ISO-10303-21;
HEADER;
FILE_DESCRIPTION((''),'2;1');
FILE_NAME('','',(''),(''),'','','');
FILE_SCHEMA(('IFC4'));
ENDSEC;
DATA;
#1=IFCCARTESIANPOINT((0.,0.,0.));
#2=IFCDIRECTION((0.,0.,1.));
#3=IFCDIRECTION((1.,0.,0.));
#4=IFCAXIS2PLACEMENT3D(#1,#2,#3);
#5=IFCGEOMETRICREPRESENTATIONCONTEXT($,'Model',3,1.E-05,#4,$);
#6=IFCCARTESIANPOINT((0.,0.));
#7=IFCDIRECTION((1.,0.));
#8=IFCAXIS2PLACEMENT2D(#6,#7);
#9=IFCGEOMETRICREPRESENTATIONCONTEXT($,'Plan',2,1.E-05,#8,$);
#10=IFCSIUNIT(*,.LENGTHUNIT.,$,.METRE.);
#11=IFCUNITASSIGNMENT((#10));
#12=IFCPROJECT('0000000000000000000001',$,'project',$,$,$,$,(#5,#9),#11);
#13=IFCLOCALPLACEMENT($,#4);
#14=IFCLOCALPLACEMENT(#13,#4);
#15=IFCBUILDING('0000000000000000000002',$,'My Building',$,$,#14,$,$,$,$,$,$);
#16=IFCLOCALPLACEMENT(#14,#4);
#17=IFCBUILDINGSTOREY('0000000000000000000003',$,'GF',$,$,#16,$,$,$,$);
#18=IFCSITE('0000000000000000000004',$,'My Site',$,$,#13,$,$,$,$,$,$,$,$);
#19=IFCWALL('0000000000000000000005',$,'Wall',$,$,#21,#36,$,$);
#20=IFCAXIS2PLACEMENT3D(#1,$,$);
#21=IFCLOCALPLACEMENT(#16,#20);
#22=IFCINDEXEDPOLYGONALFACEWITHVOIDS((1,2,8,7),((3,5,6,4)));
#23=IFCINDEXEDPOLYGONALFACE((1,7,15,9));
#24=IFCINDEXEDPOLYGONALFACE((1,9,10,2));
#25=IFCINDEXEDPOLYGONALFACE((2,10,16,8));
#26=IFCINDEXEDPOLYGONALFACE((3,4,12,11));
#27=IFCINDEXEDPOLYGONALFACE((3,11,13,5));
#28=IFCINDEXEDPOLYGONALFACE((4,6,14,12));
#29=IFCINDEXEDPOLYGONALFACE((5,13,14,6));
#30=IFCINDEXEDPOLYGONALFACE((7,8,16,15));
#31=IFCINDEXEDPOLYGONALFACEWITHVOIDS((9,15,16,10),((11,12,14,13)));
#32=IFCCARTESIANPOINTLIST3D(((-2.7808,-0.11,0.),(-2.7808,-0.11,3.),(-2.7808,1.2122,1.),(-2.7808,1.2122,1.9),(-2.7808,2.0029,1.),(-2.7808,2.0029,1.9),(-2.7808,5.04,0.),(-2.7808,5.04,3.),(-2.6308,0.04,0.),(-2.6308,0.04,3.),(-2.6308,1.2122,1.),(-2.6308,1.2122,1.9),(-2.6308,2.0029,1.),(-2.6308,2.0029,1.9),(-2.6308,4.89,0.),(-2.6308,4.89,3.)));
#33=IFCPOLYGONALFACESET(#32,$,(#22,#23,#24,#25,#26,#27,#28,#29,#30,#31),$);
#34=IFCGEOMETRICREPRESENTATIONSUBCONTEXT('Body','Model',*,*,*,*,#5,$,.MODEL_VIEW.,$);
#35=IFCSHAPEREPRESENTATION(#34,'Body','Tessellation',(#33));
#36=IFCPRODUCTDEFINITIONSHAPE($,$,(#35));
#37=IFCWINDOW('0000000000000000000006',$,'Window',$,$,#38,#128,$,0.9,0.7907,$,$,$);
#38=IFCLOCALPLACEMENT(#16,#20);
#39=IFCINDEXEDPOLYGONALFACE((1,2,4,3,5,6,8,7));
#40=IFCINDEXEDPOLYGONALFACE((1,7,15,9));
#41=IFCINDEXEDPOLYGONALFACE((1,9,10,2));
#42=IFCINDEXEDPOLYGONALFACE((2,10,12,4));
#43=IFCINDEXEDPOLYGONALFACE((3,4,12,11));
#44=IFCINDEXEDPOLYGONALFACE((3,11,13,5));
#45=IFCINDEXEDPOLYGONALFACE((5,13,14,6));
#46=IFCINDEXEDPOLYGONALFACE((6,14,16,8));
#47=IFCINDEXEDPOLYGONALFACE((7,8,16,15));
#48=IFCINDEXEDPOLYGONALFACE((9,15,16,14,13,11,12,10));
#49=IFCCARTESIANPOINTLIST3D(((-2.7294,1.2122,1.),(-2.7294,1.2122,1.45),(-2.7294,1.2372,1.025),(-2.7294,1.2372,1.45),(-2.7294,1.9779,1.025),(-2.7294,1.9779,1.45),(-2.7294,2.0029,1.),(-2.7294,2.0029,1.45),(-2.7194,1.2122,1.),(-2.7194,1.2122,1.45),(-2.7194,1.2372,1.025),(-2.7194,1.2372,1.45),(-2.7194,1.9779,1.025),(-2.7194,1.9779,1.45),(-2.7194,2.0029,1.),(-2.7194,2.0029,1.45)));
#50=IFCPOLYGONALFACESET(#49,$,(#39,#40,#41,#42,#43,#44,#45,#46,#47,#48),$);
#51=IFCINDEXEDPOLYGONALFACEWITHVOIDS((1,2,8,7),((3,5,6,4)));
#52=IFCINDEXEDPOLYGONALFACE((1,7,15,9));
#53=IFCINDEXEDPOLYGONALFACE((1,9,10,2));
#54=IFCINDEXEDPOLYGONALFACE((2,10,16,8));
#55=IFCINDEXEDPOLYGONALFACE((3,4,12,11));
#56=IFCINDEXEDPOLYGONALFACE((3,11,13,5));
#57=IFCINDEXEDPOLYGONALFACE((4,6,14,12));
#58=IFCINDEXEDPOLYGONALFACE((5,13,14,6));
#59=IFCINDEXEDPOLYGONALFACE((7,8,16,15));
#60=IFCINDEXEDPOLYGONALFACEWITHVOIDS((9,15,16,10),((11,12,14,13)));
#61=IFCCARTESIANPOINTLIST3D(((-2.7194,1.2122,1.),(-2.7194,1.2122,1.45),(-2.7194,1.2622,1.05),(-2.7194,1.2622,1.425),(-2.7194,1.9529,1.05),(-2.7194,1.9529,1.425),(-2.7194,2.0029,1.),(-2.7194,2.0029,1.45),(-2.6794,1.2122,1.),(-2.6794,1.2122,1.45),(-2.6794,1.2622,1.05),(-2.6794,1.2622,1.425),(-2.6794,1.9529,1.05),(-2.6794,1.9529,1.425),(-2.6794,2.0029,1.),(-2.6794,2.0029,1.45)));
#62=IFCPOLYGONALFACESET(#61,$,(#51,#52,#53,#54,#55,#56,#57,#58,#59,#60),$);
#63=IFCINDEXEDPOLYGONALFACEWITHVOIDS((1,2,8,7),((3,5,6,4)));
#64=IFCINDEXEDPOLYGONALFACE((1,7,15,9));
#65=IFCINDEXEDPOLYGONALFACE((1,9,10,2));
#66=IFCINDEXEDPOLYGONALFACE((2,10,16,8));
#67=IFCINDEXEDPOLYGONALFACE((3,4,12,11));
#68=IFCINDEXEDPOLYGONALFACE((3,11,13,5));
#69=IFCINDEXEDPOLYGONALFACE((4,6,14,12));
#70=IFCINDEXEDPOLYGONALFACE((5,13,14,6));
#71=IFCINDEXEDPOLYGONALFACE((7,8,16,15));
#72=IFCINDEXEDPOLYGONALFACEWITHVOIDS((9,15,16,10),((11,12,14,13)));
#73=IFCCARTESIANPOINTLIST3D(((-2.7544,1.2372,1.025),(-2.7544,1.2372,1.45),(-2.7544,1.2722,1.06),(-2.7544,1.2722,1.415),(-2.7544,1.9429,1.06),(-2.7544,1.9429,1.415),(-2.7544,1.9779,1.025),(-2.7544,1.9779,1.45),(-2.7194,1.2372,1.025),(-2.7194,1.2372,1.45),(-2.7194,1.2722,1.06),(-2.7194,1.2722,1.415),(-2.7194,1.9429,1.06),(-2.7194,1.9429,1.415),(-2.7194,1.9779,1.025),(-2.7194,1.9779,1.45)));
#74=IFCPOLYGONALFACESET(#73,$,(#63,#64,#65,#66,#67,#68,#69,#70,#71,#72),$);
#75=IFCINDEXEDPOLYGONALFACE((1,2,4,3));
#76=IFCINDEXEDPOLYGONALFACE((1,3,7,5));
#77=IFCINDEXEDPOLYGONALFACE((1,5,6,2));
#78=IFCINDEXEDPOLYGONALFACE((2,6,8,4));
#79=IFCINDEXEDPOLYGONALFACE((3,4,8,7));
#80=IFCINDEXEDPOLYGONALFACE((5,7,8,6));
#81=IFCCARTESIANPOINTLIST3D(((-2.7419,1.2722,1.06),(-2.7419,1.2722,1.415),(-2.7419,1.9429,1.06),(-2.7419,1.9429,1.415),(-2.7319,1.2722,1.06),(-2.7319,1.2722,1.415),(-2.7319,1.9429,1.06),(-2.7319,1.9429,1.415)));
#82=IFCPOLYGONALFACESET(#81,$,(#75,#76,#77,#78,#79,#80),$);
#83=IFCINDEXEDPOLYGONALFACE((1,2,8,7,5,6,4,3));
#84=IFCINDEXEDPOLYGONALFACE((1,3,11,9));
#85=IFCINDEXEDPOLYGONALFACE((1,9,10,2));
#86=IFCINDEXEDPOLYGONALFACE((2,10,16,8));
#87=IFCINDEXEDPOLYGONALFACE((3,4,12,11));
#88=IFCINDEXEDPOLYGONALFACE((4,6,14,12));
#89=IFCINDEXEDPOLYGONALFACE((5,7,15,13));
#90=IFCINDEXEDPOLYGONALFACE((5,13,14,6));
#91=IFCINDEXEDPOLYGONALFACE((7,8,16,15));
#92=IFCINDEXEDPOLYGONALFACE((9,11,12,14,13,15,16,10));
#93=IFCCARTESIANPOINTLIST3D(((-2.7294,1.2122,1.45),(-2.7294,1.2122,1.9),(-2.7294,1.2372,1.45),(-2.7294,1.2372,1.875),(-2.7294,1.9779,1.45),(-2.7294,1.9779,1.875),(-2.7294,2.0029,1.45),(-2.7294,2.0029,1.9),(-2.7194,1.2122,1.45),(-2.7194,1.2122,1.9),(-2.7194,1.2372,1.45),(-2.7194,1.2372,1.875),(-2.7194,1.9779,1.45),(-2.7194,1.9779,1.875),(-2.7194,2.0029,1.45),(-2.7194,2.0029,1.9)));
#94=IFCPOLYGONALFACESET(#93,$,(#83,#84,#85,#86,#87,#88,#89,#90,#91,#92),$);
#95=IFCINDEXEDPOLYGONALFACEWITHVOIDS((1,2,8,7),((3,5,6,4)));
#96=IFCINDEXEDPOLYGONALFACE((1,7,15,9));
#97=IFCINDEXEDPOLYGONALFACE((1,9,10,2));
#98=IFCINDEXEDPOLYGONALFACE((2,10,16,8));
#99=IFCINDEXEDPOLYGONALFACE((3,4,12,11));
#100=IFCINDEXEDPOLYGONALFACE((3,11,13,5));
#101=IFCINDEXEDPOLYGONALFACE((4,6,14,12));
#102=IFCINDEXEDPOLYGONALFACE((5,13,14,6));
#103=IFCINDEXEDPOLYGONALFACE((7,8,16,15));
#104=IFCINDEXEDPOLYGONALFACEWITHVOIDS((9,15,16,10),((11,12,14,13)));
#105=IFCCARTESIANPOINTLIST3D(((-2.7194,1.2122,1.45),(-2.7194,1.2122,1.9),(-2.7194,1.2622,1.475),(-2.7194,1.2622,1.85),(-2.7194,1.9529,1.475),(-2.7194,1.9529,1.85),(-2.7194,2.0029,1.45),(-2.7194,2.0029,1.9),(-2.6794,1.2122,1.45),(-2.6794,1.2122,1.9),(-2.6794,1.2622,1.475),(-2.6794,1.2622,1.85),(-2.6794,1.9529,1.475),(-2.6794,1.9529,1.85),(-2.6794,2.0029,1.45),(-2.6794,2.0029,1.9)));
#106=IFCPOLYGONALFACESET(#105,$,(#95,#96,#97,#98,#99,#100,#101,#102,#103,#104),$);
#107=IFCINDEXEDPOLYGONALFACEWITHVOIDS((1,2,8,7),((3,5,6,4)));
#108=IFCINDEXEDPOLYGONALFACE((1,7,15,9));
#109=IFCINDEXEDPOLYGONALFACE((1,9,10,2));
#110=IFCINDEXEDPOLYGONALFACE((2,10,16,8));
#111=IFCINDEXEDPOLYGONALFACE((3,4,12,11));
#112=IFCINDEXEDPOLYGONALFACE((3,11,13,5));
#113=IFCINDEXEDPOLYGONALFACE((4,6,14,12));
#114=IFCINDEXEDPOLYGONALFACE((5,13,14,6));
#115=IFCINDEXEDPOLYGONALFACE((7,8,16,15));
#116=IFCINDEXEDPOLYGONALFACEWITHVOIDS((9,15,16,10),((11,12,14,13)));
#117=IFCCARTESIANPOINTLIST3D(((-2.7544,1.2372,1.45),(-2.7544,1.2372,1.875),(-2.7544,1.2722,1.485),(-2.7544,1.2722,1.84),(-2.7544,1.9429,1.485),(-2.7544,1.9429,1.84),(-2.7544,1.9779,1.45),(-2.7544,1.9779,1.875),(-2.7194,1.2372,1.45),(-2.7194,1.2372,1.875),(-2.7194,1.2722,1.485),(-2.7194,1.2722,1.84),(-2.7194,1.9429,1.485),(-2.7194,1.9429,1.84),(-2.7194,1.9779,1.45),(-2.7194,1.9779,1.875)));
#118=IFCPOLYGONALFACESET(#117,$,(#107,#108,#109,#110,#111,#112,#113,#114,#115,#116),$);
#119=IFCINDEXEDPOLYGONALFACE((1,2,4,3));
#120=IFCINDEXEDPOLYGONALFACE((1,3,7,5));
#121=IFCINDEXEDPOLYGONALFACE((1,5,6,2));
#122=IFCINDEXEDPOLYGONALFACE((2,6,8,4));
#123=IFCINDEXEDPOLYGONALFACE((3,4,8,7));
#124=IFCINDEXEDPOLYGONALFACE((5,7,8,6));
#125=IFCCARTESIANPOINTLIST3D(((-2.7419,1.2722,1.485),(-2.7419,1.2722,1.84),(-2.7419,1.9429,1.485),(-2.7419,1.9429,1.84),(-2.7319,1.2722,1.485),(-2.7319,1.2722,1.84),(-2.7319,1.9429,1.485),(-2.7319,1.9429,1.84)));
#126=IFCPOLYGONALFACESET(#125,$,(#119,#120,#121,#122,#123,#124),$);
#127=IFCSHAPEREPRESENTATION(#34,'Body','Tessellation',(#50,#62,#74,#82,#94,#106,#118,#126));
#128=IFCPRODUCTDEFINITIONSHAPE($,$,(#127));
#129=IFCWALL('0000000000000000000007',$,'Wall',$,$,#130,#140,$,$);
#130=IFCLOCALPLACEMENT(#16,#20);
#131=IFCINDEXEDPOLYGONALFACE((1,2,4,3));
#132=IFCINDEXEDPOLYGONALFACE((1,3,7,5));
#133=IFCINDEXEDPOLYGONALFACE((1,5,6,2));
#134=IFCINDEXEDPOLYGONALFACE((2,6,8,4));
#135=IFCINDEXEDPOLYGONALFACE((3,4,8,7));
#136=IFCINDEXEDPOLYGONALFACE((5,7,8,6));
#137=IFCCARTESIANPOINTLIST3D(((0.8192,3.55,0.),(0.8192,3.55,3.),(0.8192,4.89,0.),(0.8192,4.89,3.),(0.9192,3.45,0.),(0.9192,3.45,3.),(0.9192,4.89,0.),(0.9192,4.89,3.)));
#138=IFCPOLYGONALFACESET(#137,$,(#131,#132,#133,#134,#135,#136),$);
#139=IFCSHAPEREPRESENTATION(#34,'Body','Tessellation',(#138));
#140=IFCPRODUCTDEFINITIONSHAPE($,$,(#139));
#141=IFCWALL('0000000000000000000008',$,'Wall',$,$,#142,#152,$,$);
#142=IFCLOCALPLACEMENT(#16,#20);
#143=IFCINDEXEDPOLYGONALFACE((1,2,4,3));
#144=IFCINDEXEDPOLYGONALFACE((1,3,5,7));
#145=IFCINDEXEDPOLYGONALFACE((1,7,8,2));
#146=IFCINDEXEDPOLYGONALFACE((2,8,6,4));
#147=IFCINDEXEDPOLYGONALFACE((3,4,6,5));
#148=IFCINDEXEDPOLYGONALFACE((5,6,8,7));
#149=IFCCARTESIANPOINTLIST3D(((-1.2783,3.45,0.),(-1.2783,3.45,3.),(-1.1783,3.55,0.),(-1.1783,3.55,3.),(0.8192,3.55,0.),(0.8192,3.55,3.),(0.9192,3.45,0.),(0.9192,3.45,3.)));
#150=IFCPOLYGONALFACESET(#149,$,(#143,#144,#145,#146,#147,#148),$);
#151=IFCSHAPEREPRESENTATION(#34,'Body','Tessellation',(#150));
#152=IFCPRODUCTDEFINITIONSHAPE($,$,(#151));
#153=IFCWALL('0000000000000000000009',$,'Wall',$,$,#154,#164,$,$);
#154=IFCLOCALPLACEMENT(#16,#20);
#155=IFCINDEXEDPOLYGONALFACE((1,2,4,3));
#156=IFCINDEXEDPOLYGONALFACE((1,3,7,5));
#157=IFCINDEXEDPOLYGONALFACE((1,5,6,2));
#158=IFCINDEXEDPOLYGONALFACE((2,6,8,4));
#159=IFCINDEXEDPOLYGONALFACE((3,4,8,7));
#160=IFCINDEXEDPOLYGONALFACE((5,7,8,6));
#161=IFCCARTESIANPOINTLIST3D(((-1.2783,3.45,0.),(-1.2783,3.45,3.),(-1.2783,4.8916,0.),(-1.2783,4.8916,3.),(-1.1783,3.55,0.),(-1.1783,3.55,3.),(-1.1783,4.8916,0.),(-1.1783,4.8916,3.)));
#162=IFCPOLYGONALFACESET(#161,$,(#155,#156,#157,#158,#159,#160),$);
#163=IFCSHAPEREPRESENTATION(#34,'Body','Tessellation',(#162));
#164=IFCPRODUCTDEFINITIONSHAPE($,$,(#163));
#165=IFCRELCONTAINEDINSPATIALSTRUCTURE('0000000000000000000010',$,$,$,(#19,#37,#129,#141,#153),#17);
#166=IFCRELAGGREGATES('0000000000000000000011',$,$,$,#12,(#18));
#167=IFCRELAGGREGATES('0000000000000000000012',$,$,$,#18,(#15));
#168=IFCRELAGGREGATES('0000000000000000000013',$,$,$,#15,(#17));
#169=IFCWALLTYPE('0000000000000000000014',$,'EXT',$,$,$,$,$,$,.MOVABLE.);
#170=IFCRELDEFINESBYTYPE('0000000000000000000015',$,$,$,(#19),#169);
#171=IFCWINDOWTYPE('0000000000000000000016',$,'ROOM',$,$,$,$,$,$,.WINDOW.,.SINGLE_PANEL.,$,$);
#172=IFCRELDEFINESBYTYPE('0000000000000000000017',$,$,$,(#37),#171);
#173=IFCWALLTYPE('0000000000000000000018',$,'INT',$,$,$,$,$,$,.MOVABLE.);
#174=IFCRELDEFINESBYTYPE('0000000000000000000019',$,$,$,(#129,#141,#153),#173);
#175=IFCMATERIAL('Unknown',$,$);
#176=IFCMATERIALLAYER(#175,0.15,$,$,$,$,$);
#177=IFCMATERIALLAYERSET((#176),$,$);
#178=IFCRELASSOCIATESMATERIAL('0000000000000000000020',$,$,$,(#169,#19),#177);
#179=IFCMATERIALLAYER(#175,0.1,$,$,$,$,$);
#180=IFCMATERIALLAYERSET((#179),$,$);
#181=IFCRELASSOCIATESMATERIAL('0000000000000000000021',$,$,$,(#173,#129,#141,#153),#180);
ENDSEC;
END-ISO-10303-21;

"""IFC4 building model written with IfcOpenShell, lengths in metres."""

from ifc_helpers import new_model, entity, si_unit, frame, origin_with_axes, origin_2d_with_axis, place, context, subcontext, project, spatial, line, indexed_curve, outline, extrude, shape, source, transform, mapped, material, layer, layer_set, layer_usage, type_object, type_shapes, element, fill, save


model = new_model("IFC4")

# Units and contexts
model_context = context("Model", 3, precision=1e-05, world=origin_with_axes())
plan_context = context("Plan", 2, precision=1e-05, world=origin_2d_with_axis())
body_context_1 = subcontext(model_context, "Body", "Model", "MODEL_VIEW")
body_context_2 = subcontext(plan_context, "Body", "Plan", "PLAN_VIEW")
ifc_project = project(units=[si_unit("LENGTHUNIT", "METRE")], contexts=[model_context, plan_context])

# Site, building, storey
site_placement = place(None, origin_with_axes())
site = spatial("IfcSite", under=ifc_project, at=site_placement, Name="My Site")
building_placement = place(site_placement, origin_with_axes())
building = spatial("IfcBuilding", under=site, at=building_placement, Name="My Building")
storey_placement = place(building_placement, origin_with_axes())
storey = spatial("IfcBuildingStorey", under=building, at=storey_placement, Name="GF")

# Shared definitions
ifc_material = material(Name="Unknown")

# Shared definitions
ifc_layer_1 = layer(ifc_material, 0.15)
ifc_layer_set_1 = layer_set([ifc_layer_1])
wall_type_1 = type_object("IfcWallType", Name="EXT", PredefinedType="MOVABLE", material=ifc_layer_set_1)

# Shared definitions
window_type_1 = type_object("IfcWindowType", Name="ROOM", PartitioningType="SINGLE_PANEL", PredefinedType="WINDOW")
shared_shape_1 = source(origin_with_axes(), body_context_1, "Body", "SweptSolid", [
    extrude(outline(indexed_curve([(0.7907, 0.45), (0.7907, 0.0), (0.0, 0.0), (0.0, 0.45), (0.025, 0.45), (0.025, 0.025), (0.7657, 0.025), (0.7657, 0.45)], segments=[line(1, 2, 3, 4, 5, 6, 7, 8, 1)])), frame((0.0, 0.09, 0.0), z_axis=(0.0, -1.0, 0.0), x_axis=(1.0, 0.0, 0.0)), (0.0, 0.0, -1.0), 0.01),
    extrude(outline(indexed_curve([(0.0, 0.0), (0.7907, 0.0), (0.7907, 0.45), (0.0, 0.45)], segments=[line(1, 2, 3, 4, 1)]), holes=[indexed_curve([(0.05, 0.05), (0.7407, 0.05), (0.7407, 0.425), (0.05, 0.425)], segments=[line(1, 2, 3, 4, 1)])]), frame((0.0, 0.05, 0.0), z_axis=(0.0, -1.0, 0.0), x_axis=(1.0, 0.0, 0.0)), (0.0, 0.0, -1.0), 0.04),
    extrude(outline(indexed_curve([(0.0, 0.0), (0.7407, 0.0), (0.7407, 0.425), (0.0, 0.425)], segments=[line(1, 2, 3, 4, 1)]), holes=[indexed_curve([(0.035, 0.035), (0.7057, 0.035), (0.7057, 0.39), (0.035, 0.39)], segments=[line(1, 2, 3, 4, 1)])]), frame((0.025, 0.09, 0.025), z_axis=(0.0, -1.0, 0.0), x_axis=(1.0, 0.0, 0.0)), (0.0, 0.0, -1.0), 0.035),
    extrude(outline(indexed_curve([(0.035, 0.035), (0.7057, 0.035), (0.7057, 0.39), (0.035, 0.39)], segments=[line(1, 2, 3, 4, 1)])), frame((0.025, 0.1025, 0.025), z_axis=(0.0, -1.0, 0.0), x_axis=(1.0, 0.0, 0.0)), (0.0, 0.0, -1.0), 0.01),
    extrude(outline(indexed_curve([(0.0, 0.0), (0.0, 0.45), (0.7907, 0.45), (0.7907, 0.0), (0.7657, 0.0), (0.7657, 0.425), (0.025, 0.425), (0.025, 0.0)], segments=[line(1, 2, 3, 4, 5, 6, 7, 8, 1)])), frame((0.0, 0.09, 0.45), z_axis=(0.0, -1.0, 0.0), x_axis=(1.0, 0.0, 0.0)), (0.0, 0.0, -1.0), 0.01),
    extrude(outline(indexed_curve([(0.0, 0.0), (0.7907, 0.0), (0.7907, 0.45), (0.0, 0.45)], segments=[line(1, 2, 3, 4, 1)]), holes=[indexed_curve([(0.05, 0.025), (0.7407, 0.025), (0.7407, 0.4), (0.05, 0.4)], segments=[line(1, 2, 3, 4, 1)])]), frame((0.0, 0.05, 0.45), z_axis=(0.0, -1.0, 0.0), x_axis=(1.0, 0.0, 0.0)), (0.0, 0.0, -1.0), 0.04),
    extrude(outline(indexed_curve([(0.0, 0.0), (0.7407, 0.0), (0.7407, 0.425), (0.0, 0.425)], segments=[line(1, 2, 3, 4, 1)]), holes=[indexed_curve([(0.035, 0.035), (0.7057, 0.035), (0.7057, 0.39), (0.035, 0.39)], segments=[line(1, 2, 3, 4, 1)])]), frame((0.025, 0.09, 0.45), z_axis=(0.0, -1.0, 0.0), x_axis=(1.0, 0.0, 0.0)), (0.0, 0.0, -1.0), 0.035),
    extrude(outline(indexed_curve([(0.035, 0.035), (0.7057, 0.035), (0.7057, 0.39), (0.035, 0.39)], segments=[line(1, 2, 3, 4, 1)])), frame((0.025, 0.1025, 0.45), z_axis=(0.0, -1.0, 0.0), x_axis=(1.0, 0.0, 0.0)), (0.0, 0.0, -1.0), 0.01),
])
shared_shape_2 = source(origin_with_axes(), body_context_2, "Body", "Curve2D", [
    entity("IfcIndexedPolyCurve", entity("IfcCartesianPointList2D", [[0.05, 0.05], [0.7407, 0.05]])),
    entity("IfcIndexedPolyCurve", entity("IfcCartesianPointList2D", [[0.0, 0.1], [0.025, 0.1], [0.025, 0.09], [0.05, 0.09], [0.05, 0.05], [0.0, 0.05]]), [entity("IfcLineIndex", [1, 2, 3, 4, 5, 6, 1])]),
    entity("IfcIndexedPolyCurve", entity("IfcCartesianPointList2D", [[0.7907, 0.1], [0.7657, 0.1], [0.7657, 0.09], [0.7407, 0.09], [0.7407, 0.05], [0.7907, 0.05]]), [entity("IfcLineIndex", [1, 2, 3, 4, 5, 6, 1])]),
    entity("IfcIndexedPolyCurve", entity("IfcCartesianPointList2D", [[0.025, 0.09], [0.06, 0.09], [0.06, 0.125], [0.025, 0.125]]), [entity("IfcLineIndex", [1, 2, 3, 4, 1])]),
    entity("IfcIndexedPolyCurve", entity("IfcCartesianPointList2D", [[0.7657, 0.09], [0.7307, 0.09], [0.7307, 0.125], [0.7657, 0.125]]), [entity("IfcLineIndex", [1, 2, 3, 4, 1])]),
    entity("IfcIndexedPolyCurve", entity("IfcCartesianPointList2D", [[0.06, 0.09], [0.7307, 0.09]])),
    entity("IfcIndexedPolyCurve", entity("IfcCartesianPointList2D", [[0.06, 0.125], [0.7307, 0.125]])),
    entity("IfcIndexedPolyCurve", entity("IfcCartesianPointList2D", [[0.06, 0.1075], [0.7307, 0.1075]])),
])
type_shapes(window_type_1, [shared_shape_1, shared_shape_2])

# Wall, opening, window
ifc_layer_usage_1 = layer_usage(ifc_layer_set_1, "AXIS2", "POSITIVE", 0.0)
wall_1_placement = place(storey_placement, frame((-2.7808, 5.04, 0.0), z_axis=(0.0, 0.0, 1.0), x_axis=(0.0, -1.0, 0.0)))
wall_1 = element("IfcWall", 1, at=wall_1_placement, inside=storey, type_object=wall_type_1, material=ifc_layer_usage_1, Name="Wall", context=body_context_1, shape_type="SweptSolid", body=[
    extrude(outline(indexed_curve([(0.0, 0.0), (0.15, 0.15), (5.0, 0.15), (5.15, 0.0)], segments=[line(1, 2, 3, 4, 1)])), origin_with_axes(), (0.0, 0.0, 1.0), 3.0),
])
placement_1 = place(storey_placement, frame((-2.6294, 1.2122, 1.0), z_axis=(0.0, 0.0, 1.0), x_axis=(0.0, 1.0, 0.0)))
opening_1 = element("IfcOpeningElement", 2, at=placement_1, cuts=wall_1, PredefinedType="OPENING", context=body_context_1, shape_type="SweptSolid", body=[
    extrude(outline(indexed_curve([(0.0, 0.0), (0.7907, 0.0), (0.7907, 0.9), (0.0, 0.9)], segments=[line(1, 2, 3, 4, 1)])), frame((0.0, -0.6, 0.0), z_axis=(0.0, -1.0, 0.0), x_axis=(1.0, 0.0, 0.0)), (0.0, 0.0, -1.0), 1.2),
])
window_1 = element("IfcWindow", 3, at=placement_1, inside=storey, type_object=window_type_1, Name="Window", OverallHeight=0.9, OverallWidth=0.7907, shapes=[
    shape(body_context_1, "Body", "MappedRepresentation", [mapped(shared_shape_1, transform((0.0, 0.0, 0.0), x_axis=(1.0, 0.0, 0.0), y_axis=(0.0, 1.0, 0.0), z_axis=(0.0, 0.0, 1.0), scale=1.0))]),
    shape(body_context_2, "Body", "MappedRepresentation", [mapped(shared_shape_2, transform((0.0, 0.0, 0.0), x_axis=(1.0, 0.0, 0.0), y_axis=(0.0, 1.0, 0.0), z_axis=(0.0, 0.0, 1.0), scale=1.0))]),
])
fill(opening_1, window_1)

# Walls
ifc_layer_2 = layer(ifc_material, 0.1)
ifc_layer_set_2 = layer_set([ifc_layer_2])
ifc_layer_usage_2 = layer_usage(ifc_layer_set_2, "AXIS2", "POSITIVE", -0.1)
wall_type_2 = type_object("IfcWallType", Name="INT", PredefinedType="MOVABLE", material=ifc_layer_set_2)
wall_2_placement = place(storey_placement, frame((0.9192, 4.89, 0.0), z_axis=(0.0, 0.0, 1.0), x_axis=(0.0, -1.0, 0.0)))
element("IfcWall", 4, at=wall_2_placement, inside=storey, type_object=wall_type_2, material=ifc_layer_usage_2, Name="Wall", context=body_context_1, shape_type="SweptSolid", body=[
    extrude(outline(indexed_curve([(0.0, -0.1), (0.0, 0.0), (1.44, 0.0), (1.34, -0.1)], segments=[line(1, 2, 3, 4, 1)])), origin_with_axes(), (0.0, 0.0, 1.0), 3.0),
])
ifc_layer_usage_3 = layer_usage(ifc_layer_set_2, "AXIS2", "POSITIVE", -0.1)
wall_3_placement = place(storey_placement, frame((0.9192, 3.45, 0.0), z_axis=(0.0, 0.0, 1.0), x_axis=(-1.0, 0.0, 0.0)))
element("IfcWall", 5, at=wall_3_placement, inside=storey, type_object=wall_type_2, material=ifc_layer_usage_3, Name="Wall", context=body_context_1, shape_type="SweptSolid", body=[
    extrude(outline(indexed_curve([(0.1, -0.1), (0.0, 0.0), (2.1975, 0.0), (2.0975, -0.1)], segments=[line(1, 2, 3, 4, 1)])), origin_with_axes(), (0.0, 0.0, 1.0), 3.0),
])
ifc_layer_usage_4 = layer_usage(ifc_layer_set_2, "AXIS2", "POSITIVE", -0.1)
wall_4_placement = place(storey_placement, frame((-1.2783, 3.45, 0.0), z_axis=(0.0, 0.0, 1.0), x_axis=(0.0, 1.0, 0.0)))
element("IfcWall", 6, at=wall_4_placement, inside=storey, type_object=wall_type_2, material=ifc_layer_usage_4, Name="Wall", context=body_context_1, shape_type="SweptSolid", body=[
    extrude(outline(indexed_curve([(0.1, -0.1), (0.0, 0.0), (1.4416, 0.0), (1.4416, -0.1)], segments=[line(1, 2, 3, 4, 1)])), origin_with_axes(), (0.0, 0.0, 1.0), 3.0),
])

save(model, "model.ifc")
